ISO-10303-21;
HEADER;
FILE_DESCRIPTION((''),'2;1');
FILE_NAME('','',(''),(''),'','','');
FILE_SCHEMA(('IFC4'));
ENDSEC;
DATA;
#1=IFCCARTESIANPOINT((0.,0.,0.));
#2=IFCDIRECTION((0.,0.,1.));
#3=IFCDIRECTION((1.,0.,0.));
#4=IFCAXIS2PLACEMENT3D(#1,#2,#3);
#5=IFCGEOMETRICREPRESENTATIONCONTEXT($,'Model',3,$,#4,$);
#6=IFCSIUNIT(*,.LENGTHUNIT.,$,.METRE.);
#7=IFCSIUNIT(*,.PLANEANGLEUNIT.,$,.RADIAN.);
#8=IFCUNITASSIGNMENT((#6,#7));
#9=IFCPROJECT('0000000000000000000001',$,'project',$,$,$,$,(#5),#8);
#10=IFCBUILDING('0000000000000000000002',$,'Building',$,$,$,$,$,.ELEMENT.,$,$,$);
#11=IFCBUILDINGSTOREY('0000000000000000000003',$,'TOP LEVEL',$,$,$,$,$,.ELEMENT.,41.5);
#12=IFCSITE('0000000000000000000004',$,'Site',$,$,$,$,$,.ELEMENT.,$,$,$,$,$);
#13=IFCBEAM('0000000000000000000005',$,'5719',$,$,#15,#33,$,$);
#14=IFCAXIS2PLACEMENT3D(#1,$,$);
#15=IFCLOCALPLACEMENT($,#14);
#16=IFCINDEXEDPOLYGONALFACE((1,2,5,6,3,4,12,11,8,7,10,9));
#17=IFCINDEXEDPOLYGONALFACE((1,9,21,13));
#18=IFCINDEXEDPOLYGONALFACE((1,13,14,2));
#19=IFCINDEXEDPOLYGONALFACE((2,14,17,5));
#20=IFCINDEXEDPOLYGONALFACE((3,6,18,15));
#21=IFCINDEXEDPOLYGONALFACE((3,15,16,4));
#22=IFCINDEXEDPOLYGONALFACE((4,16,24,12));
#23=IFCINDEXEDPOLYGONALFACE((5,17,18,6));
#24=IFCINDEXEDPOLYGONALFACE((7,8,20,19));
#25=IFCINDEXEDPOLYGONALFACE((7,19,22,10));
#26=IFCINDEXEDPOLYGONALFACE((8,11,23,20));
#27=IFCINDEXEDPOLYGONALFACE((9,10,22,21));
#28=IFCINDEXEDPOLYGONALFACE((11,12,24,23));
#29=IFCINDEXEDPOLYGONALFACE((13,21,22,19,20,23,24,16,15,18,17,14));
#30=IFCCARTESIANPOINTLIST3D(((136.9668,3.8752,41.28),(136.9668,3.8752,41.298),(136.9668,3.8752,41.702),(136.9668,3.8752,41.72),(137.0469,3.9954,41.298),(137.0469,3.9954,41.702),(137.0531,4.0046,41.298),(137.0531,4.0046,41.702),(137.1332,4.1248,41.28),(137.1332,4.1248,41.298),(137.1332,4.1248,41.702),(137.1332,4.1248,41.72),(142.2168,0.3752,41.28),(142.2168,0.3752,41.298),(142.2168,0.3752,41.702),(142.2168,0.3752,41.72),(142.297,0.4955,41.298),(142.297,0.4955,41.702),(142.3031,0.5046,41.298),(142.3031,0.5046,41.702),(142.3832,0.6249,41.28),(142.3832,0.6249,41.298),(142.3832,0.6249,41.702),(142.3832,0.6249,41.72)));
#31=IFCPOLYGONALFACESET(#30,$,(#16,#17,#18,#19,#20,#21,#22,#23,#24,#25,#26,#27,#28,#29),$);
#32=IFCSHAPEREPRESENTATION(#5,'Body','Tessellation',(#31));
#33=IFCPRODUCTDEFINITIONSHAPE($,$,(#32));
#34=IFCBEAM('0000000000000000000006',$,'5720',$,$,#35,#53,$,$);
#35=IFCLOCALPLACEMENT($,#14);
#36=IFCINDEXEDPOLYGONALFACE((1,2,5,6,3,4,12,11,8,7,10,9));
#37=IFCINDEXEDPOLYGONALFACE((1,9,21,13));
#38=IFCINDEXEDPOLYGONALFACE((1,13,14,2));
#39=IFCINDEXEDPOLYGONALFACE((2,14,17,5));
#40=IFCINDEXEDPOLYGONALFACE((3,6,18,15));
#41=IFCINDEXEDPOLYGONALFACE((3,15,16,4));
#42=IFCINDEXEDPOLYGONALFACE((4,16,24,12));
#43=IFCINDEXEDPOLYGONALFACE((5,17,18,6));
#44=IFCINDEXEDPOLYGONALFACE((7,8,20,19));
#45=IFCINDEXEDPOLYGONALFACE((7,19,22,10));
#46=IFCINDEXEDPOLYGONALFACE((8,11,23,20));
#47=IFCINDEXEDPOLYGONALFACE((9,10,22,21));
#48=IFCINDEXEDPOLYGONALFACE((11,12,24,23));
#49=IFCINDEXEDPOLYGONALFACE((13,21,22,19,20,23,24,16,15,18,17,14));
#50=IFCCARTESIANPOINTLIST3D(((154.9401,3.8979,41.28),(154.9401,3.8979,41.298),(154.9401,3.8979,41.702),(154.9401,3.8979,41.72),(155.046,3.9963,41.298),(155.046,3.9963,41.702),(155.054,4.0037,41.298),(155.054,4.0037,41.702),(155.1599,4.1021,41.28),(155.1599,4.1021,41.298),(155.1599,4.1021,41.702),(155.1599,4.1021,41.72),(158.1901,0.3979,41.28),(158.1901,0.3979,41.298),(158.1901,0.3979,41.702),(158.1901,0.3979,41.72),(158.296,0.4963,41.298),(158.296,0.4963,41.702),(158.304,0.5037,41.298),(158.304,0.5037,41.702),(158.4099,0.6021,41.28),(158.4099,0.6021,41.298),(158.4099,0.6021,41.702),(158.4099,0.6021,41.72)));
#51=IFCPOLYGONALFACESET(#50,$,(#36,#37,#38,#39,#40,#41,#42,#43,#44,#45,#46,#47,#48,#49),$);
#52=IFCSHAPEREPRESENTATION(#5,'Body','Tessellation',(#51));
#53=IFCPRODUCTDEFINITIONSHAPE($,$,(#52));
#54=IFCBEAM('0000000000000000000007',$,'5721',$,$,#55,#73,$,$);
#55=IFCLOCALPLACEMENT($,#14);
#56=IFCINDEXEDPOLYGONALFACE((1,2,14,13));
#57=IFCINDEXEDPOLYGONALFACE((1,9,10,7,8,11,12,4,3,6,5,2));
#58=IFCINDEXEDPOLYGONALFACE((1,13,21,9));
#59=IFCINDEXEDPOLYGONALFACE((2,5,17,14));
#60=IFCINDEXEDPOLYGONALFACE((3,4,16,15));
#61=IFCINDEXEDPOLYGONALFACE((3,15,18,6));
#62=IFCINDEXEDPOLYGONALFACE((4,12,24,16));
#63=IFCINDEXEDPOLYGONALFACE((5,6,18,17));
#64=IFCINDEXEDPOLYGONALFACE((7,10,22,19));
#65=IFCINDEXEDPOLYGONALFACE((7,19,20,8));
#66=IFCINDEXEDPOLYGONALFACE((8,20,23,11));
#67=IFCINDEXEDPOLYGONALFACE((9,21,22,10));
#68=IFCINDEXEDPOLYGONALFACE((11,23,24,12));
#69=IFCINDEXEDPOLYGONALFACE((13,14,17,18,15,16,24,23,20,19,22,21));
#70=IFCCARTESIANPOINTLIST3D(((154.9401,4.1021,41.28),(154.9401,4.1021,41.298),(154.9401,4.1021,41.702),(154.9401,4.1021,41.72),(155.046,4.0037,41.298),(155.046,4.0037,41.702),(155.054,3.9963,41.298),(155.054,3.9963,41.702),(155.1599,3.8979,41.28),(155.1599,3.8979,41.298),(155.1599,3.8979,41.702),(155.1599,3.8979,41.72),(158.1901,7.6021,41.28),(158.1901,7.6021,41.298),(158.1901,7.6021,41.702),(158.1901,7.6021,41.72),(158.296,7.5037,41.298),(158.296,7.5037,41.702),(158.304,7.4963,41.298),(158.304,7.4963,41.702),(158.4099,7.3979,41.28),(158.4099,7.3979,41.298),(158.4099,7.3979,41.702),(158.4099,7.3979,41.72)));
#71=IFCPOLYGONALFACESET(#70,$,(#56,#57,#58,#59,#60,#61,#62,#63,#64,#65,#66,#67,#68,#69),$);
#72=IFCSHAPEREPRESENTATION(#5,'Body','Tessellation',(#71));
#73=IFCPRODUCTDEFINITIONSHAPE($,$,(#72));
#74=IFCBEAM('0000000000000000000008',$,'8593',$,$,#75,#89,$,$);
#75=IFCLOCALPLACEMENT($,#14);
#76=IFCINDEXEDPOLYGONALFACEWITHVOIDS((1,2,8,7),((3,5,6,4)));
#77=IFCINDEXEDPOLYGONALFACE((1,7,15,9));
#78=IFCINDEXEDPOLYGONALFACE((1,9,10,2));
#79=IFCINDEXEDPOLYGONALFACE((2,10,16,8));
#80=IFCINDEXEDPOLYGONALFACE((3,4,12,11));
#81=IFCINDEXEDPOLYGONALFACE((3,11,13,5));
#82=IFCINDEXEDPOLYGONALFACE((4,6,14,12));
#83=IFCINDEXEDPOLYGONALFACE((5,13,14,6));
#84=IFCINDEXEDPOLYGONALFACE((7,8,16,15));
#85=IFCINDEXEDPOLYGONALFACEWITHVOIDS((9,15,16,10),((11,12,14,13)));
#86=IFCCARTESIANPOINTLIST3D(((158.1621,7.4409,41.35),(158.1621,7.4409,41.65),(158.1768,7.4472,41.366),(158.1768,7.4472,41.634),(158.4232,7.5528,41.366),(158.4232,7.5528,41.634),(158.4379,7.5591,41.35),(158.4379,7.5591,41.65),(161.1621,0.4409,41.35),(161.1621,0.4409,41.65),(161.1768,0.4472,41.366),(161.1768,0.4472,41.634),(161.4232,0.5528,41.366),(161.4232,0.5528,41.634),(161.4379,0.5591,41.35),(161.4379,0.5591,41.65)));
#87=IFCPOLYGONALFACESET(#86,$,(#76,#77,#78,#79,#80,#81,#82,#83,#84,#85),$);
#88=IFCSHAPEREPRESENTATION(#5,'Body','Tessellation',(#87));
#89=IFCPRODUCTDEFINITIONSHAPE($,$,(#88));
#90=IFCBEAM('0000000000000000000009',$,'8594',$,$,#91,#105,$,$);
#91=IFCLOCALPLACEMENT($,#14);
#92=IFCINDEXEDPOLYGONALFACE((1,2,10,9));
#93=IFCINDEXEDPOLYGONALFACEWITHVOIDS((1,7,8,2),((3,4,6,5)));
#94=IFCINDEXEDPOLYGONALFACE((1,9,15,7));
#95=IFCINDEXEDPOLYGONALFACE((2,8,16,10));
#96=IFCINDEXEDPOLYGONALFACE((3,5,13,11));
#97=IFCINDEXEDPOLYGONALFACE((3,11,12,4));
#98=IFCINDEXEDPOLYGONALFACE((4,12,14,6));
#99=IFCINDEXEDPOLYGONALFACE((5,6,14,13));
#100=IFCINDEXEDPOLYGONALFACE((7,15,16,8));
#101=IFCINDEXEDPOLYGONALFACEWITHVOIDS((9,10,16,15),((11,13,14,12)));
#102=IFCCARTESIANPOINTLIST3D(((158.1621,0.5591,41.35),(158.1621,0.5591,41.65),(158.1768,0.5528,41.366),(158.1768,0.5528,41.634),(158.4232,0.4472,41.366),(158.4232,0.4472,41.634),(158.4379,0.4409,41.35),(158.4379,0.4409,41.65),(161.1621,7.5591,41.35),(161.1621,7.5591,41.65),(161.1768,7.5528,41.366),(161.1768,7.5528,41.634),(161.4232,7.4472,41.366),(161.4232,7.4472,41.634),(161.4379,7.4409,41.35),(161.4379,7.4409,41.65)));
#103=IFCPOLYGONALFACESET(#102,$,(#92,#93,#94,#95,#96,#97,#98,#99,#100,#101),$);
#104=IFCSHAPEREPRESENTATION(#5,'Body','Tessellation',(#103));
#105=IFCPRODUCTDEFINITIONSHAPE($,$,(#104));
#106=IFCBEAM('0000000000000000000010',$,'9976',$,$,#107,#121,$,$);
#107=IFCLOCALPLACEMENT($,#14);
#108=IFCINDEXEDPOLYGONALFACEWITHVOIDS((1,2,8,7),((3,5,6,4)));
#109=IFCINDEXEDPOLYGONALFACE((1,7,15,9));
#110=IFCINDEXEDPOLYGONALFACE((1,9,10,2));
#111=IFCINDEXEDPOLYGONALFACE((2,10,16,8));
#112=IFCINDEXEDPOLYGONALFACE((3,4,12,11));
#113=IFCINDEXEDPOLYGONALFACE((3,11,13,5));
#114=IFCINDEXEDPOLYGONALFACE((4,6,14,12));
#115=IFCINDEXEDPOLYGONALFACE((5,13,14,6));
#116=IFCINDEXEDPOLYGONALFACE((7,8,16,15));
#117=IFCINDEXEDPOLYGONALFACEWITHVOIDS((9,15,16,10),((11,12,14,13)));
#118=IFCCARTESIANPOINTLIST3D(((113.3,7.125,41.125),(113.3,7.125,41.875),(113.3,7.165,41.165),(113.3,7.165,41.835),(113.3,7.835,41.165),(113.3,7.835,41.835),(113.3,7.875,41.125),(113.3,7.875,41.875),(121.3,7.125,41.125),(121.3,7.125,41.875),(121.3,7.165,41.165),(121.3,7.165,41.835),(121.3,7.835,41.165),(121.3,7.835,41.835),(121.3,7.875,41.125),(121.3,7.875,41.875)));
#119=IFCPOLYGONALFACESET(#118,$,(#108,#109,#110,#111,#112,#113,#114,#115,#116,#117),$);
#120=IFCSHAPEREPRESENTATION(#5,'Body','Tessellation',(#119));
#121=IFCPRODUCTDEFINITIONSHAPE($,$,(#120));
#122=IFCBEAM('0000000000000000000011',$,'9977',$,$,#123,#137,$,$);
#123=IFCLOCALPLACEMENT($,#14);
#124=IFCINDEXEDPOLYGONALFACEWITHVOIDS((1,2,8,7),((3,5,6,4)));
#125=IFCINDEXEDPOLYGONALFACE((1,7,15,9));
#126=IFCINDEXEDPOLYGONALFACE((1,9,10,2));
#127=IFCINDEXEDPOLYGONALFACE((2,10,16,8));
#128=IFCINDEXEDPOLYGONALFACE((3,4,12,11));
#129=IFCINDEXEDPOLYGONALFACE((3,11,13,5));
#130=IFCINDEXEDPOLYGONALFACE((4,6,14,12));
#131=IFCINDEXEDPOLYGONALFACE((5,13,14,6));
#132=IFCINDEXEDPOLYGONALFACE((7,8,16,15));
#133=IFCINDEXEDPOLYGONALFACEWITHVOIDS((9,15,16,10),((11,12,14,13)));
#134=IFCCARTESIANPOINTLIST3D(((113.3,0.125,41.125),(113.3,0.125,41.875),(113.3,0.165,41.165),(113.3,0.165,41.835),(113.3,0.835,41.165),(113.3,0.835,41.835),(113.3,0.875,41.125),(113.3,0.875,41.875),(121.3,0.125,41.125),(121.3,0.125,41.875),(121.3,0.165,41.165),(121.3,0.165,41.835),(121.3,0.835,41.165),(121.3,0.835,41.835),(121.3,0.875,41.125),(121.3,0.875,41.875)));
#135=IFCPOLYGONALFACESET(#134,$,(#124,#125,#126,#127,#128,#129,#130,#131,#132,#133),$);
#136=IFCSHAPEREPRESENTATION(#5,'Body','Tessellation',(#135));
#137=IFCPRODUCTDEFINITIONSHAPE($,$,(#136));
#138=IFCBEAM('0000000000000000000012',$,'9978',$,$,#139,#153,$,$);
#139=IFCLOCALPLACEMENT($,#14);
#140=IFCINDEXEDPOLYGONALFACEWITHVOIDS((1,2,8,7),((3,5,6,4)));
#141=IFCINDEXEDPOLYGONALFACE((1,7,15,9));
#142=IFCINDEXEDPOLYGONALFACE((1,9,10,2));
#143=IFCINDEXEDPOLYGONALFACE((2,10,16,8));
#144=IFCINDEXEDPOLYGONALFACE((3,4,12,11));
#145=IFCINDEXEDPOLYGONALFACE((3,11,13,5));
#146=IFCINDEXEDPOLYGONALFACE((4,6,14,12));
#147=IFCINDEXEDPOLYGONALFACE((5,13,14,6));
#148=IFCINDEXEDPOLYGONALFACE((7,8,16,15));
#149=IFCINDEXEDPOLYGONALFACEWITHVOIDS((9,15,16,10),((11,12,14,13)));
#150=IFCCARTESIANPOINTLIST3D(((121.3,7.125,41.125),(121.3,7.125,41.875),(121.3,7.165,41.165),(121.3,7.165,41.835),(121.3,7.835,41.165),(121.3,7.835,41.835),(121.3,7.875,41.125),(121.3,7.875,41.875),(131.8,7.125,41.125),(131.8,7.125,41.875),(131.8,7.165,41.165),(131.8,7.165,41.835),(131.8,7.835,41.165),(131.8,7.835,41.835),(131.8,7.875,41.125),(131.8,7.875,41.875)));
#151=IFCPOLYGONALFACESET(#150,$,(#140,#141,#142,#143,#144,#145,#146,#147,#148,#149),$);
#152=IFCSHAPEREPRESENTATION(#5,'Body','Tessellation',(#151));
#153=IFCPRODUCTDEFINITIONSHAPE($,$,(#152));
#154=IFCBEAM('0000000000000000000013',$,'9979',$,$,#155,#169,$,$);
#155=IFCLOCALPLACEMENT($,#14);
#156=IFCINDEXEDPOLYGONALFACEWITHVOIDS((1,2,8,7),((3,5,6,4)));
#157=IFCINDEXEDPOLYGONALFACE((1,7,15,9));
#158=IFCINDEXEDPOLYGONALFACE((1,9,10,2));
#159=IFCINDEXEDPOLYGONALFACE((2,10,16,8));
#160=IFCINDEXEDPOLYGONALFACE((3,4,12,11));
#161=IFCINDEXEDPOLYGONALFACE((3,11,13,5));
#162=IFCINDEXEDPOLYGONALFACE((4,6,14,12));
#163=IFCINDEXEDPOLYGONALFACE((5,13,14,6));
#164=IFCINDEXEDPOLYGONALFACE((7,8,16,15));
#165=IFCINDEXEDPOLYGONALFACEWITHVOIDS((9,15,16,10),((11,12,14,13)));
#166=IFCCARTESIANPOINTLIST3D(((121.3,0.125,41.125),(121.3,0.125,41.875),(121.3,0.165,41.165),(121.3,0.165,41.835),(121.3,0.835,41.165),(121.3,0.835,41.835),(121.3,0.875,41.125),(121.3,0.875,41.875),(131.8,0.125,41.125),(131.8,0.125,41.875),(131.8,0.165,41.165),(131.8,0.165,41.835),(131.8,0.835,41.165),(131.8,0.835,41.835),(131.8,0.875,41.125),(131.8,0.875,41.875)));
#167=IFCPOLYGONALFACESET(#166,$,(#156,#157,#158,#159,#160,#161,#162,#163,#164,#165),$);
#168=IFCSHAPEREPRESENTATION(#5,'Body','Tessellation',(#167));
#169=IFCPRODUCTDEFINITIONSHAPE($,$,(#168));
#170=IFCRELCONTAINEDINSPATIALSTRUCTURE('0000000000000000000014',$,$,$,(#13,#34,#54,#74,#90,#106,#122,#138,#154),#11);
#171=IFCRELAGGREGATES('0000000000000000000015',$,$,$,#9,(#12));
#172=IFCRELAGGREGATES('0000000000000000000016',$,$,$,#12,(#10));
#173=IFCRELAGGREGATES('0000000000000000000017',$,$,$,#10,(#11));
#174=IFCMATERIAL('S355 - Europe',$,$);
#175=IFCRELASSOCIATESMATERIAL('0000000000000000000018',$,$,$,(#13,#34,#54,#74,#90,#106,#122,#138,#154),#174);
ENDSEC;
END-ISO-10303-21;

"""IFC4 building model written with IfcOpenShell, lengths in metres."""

from ifc_helpers import new_model, si_unit, frame, origin_with_axes, origin_2d_with_axis, place, context, project, spatial, hollow_rectangle, i_section, extrude, material, material_profile, profile_set, profile_usage, element, save


model = new_model("IFC4")

# Units and contexts
model_context = context("Model", 3, world=origin_with_axes())
ifc_project = project(units=[si_unit("LENGTHUNIT", "METRE"), si_unit("PLANEANGLEUNIT", "RADIAN")], contexts=[model_context])

# Site, building, storey
site = spatial("IfcSite", under=ifc_project, Name="Site", CompositionType="ELEMENT")
building = spatial("IfcBuilding", under=site, Name="Building", CompositionType="ELEMENT")
storey = spatial("IfcBuildingStorey", under=building, Name="TOP LEVEL", CompositionType="ELEMENT", Elevation=41.5)

# Beams
ifc_material = material(Name="S355 - Europe")
ifc_material_profile_1 = material_profile(ifc_material, i_section(OverallWidth=0.3, OverallDepth=0.44, WebThickness=0.011, FlangeThickness=0.018, at=origin_2d_with_axis()))
ifc_profile_set_1 = profile_set([ifc_material_profile_1])
ifc_profile_usage_1 = profile_usage(ifc_profile_set_1, cardinal=10)
beam_1_placement = place(None, frame((137.05, 4.0, 41.5), z_axis=(0.832055, -0.554693, 0.0), x_axis=(0.554693, 0.832055, 0.0)))
element("IfcBeam", 1, at=beam_1_placement, inside=storey, material=ifc_profile_usage_1, Name="5719", context=model_context, shape_type="SweptSolid", body=[
    extrude(i_section(OverallWidth=0.3, OverallDepth=0.44, WebThickness=0.011, FlangeThickness=0.018, at=origin_2d_with_axis()), origin_with_axes(), (0.0, 0.0, 1.0), 6.3097),
])
ifc_material_profile_2 = material_profile(ifc_material, i_section(OverallWidth=0.3, OverallDepth=0.44, WebThickness=0.011, FlangeThickness=0.018, at=origin_2d_with_axis()))
ifc_profile_set_2 = profile_set([ifc_material_profile_2])
ifc_profile_usage_2 = profile_usage(ifc_profile_set_2, cardinal=10)
beam_2_placement = place(None, frame((155.05, 4.0, 41.5), z_axis=(0.680451, -0.732793, 0.0), x_axis=(0.732793, 0.680451, 0.0)))
element("IfcBeam", 2, at=beam_2_placement, inside=storey, material=ifc_profile_usage_2, Name="5720", context=model_context, shape_type="SweptSolid", body=[
    extrude(i_section(OverallWidth=0.3, OverallDepth=0.44, WebThickness=0.011, FlangeThickness=0.018, at=origin_2d_with_axis()), origin_with_axes(), (0.0, 0.0, 1.0), 4.7762),
])
ifc_material_profile_3 = material_profile(ifc_material, i_section(OverallWidth=0.3, OverallDepth=0.44, WebThickness=0.011, FlangeThickness=0.018, at=origin_2d_with_axis()))
ifc_profile_set_3 = profile_set([ifc_material_profile_3])
ifc_profile_usage_3 = profile_usage(ifc_profile_set_3, cardinal=10)
beam_3_placement = place(None, frame((155.05, 4.0, 41.5), z_axis=(0.680451, 0.732793, 0.0), x_axis=(-0.732793, 0.680451, 0.0)))
element("IfcBeam", 3, at=beam_3_placement, inside=storey, material=ifc_profile_usage_3, Name="5721", context=model_context, shape_type="SweptSolid", body=[
    extrude(i_section(OverallWidth=0.3, OverallDepth=0.44, WebThickness=0.011, FlangeThickness=0.018, at=origin_2d_with_axis()), origin_with_axes(), (0.0, 0.0, 1.0), 4.7762),
])
ifc_material_profile_4 = material_profile(ifc_material, hollow_rectangle(XDim=0.3, YDim=0.3, WallThickness=0.016, at=origin_2d_with_axis()))
ifc_profile_set_4 = profile_set([ifc_material_profile_4])
ifc_profile_usage_4 = profile_usage(ifc_profile_set_4, cardinal=10)
beam_4_placement = place(None, frame((158.3, 7.5, 41.5), z_axis=(0.393919, -0.919145, 0.0), x_axis=(0.919145, 0.393919, 0.0)))
element("IfcBeam", 4, at=beam_4_placement, inside=storey, material=ifc_profile_usage_4, Name="8593", context=model_context, shape_type="SweptSolid", body=[
    extrude(hollow_rectangle(XDim=0.3, YDim=0.3, WallThickness=0.016, at=origin_2d_with_axis()), origin_with_axes(), (0.0, 0.0, 1.0), 7.6158),
])
ifc_material_profile_5 = material_profile(ifc_material, hollow_rectangle(XDim=0.3, YDim=0.3, WallThickness=0.016, at=origin_2d_with_axis()))
ifc_profile_set_5 = profile_set([ifc_material_profile_5])
ifc_profile_usage_5 = profile_usage(ifc_profile_set_5, cardinal=10)
beam_5_placement = place(None, frame((158.3, 0.5, 41.5), z_axis=(0.393919, 0.919145, 0.0), x_axis=(-0.919145, 0.393919, 0.0)))
element("IfcBeam", 5, at=beam_5_placement, inside=storey, material=ifc_profile_usage_5, Name="8594", context=model_context, shape_type="SweptSolid", body=[
    extrude(hollow_rectangle(XDim=0.3, YDim=0.3, WallThickness=0.016, at=origin_2d_with_axis()), origin_with_axes(), (0.0, 0.0, 1.0), 7.6158),
])
ifc_material_profile_6 = material_profile(ifc_material, hollow_rectangle(XDim=0.75, YDim=0.75, WallThickness=0.04, at=origin_2d_with_axis()))
ifc_profile_set_6 = profile_set([ifc_material_profile_6])
ifc_profile_usage_6 = profile_usage(ifc_profile_set_6, cardinal=10)
beam_6_placement = place(None, frame((121.3, 7.5, 41.5), z_axis=(-1.0, 0.0, 0.0), x_axis=(0.0, -1.0, 0.0)))
element("IfcBeam", 6, at=beam_6_placement, inside=storey, material=ifc_profile_usage_6, Name="9976", context=model_context, shape_type="SweptSolid", body=[
    extrude(hollow_rectangle(XDim=0.75, YDim=0.75, WallThickness=0.04, at=origin_2d_with_axis()), origin_with_axes(), (0.0, 0.0, 1.0), 8.0),
])
ifc_material_profile_7 = material_profile(ifc_material, hollow_rectangle(XDim=0.75, YDim=0.75, WallThickness=0.04, at=origin_2d_with_axis()))
ifc_profile_set_7 = profile_set([ifc_material_profile_7])
ifc_profile_usage_7 = profile_usage(ifc_profile_set_7, cardinal=10)
beam_7_placement = place(None, frame((121.3, 0.5, 41.5), z_axis=(-1.0, 0.0, 0.0), x_axis=(0.0, -1.0, 0.0)))
element("IfcBeam", 7, at=beam_7_placement, inside=storey, material=ifc_profile_usage_7, Name="9977", context=model_context, shape_type="SweptSolid", body=[
    extrude(hollow_rectangle(XDim=0.75, YDim=0.75, WallThickness=0.04, at=origin_2d_with_axis()), origin_with_axes(), (0.0, 0.0, 1.0), 8.0),
])
ifc_material_profile_8 = material_profile(ifc_material, hollow_rectangle(XDim=0.75, YDim=0.75, WallThickness=0.04, at=origin_2d_with_axis()))
ifc_profile_set_8 = profile_set([ifc_material_profile_8])
ifc_profile_usage_8 = profile_usage(ifc_profile_set_8, cardinal=10)
beam_8_placement = place(None, frame((131.8, 7.5, 41.5), z_axis=(-1.0, 0.0, 0.0), x_axis=(0.0, -1.0, 0.0)))
element("IfcBeam", 8, at=beam_8_placement, inside=storey, material=ifc_profile_usage_8, Name="9978", context=model_context, shape_type="SweptSolid", body=[
    extrude(hollow_rectangle(XDim=0.75, YDim=0.75, WallThickness=0.04, at=origin_2d_with_axis()), origin_with_axes(), (0.0, 0.0, 1.0), 10.5),
])
ifc_material_profile_9 = material_profile(ifc_material, hollow_rectangle(XDim=0.75, YDim=0.75, WallThickness=0.04, at=origin_2d_with_axis()))
ifc_profile_set_9 = profile_set([ifc_material_profile_9])
ifc_profile_usage_9 = profile_usage(ifc_profile_set_9, cardinal=10)
beam_9_placement = place(None, frame((131.8, 0.5, 41.5), z_axis=(-1.0, 0.0, 0.0), x_axis=(0.0, -1.0, 0.0)))
element("IfcBeam", 9, at=beam_9_placement, inside=storey, material=ifc_profile_usage_9, Name="9979", context=model_context, shape_type="SweptSolid", body=[
    extrude(hollow_rectangle(XDim=0.75, YDim=0.75, WallThickness=0.04, at=origin_2d_with_axis()), origin_with_axes(), (0.0, 0.0, 1.0), 10.5),
])

save(model, "model.ifc")
